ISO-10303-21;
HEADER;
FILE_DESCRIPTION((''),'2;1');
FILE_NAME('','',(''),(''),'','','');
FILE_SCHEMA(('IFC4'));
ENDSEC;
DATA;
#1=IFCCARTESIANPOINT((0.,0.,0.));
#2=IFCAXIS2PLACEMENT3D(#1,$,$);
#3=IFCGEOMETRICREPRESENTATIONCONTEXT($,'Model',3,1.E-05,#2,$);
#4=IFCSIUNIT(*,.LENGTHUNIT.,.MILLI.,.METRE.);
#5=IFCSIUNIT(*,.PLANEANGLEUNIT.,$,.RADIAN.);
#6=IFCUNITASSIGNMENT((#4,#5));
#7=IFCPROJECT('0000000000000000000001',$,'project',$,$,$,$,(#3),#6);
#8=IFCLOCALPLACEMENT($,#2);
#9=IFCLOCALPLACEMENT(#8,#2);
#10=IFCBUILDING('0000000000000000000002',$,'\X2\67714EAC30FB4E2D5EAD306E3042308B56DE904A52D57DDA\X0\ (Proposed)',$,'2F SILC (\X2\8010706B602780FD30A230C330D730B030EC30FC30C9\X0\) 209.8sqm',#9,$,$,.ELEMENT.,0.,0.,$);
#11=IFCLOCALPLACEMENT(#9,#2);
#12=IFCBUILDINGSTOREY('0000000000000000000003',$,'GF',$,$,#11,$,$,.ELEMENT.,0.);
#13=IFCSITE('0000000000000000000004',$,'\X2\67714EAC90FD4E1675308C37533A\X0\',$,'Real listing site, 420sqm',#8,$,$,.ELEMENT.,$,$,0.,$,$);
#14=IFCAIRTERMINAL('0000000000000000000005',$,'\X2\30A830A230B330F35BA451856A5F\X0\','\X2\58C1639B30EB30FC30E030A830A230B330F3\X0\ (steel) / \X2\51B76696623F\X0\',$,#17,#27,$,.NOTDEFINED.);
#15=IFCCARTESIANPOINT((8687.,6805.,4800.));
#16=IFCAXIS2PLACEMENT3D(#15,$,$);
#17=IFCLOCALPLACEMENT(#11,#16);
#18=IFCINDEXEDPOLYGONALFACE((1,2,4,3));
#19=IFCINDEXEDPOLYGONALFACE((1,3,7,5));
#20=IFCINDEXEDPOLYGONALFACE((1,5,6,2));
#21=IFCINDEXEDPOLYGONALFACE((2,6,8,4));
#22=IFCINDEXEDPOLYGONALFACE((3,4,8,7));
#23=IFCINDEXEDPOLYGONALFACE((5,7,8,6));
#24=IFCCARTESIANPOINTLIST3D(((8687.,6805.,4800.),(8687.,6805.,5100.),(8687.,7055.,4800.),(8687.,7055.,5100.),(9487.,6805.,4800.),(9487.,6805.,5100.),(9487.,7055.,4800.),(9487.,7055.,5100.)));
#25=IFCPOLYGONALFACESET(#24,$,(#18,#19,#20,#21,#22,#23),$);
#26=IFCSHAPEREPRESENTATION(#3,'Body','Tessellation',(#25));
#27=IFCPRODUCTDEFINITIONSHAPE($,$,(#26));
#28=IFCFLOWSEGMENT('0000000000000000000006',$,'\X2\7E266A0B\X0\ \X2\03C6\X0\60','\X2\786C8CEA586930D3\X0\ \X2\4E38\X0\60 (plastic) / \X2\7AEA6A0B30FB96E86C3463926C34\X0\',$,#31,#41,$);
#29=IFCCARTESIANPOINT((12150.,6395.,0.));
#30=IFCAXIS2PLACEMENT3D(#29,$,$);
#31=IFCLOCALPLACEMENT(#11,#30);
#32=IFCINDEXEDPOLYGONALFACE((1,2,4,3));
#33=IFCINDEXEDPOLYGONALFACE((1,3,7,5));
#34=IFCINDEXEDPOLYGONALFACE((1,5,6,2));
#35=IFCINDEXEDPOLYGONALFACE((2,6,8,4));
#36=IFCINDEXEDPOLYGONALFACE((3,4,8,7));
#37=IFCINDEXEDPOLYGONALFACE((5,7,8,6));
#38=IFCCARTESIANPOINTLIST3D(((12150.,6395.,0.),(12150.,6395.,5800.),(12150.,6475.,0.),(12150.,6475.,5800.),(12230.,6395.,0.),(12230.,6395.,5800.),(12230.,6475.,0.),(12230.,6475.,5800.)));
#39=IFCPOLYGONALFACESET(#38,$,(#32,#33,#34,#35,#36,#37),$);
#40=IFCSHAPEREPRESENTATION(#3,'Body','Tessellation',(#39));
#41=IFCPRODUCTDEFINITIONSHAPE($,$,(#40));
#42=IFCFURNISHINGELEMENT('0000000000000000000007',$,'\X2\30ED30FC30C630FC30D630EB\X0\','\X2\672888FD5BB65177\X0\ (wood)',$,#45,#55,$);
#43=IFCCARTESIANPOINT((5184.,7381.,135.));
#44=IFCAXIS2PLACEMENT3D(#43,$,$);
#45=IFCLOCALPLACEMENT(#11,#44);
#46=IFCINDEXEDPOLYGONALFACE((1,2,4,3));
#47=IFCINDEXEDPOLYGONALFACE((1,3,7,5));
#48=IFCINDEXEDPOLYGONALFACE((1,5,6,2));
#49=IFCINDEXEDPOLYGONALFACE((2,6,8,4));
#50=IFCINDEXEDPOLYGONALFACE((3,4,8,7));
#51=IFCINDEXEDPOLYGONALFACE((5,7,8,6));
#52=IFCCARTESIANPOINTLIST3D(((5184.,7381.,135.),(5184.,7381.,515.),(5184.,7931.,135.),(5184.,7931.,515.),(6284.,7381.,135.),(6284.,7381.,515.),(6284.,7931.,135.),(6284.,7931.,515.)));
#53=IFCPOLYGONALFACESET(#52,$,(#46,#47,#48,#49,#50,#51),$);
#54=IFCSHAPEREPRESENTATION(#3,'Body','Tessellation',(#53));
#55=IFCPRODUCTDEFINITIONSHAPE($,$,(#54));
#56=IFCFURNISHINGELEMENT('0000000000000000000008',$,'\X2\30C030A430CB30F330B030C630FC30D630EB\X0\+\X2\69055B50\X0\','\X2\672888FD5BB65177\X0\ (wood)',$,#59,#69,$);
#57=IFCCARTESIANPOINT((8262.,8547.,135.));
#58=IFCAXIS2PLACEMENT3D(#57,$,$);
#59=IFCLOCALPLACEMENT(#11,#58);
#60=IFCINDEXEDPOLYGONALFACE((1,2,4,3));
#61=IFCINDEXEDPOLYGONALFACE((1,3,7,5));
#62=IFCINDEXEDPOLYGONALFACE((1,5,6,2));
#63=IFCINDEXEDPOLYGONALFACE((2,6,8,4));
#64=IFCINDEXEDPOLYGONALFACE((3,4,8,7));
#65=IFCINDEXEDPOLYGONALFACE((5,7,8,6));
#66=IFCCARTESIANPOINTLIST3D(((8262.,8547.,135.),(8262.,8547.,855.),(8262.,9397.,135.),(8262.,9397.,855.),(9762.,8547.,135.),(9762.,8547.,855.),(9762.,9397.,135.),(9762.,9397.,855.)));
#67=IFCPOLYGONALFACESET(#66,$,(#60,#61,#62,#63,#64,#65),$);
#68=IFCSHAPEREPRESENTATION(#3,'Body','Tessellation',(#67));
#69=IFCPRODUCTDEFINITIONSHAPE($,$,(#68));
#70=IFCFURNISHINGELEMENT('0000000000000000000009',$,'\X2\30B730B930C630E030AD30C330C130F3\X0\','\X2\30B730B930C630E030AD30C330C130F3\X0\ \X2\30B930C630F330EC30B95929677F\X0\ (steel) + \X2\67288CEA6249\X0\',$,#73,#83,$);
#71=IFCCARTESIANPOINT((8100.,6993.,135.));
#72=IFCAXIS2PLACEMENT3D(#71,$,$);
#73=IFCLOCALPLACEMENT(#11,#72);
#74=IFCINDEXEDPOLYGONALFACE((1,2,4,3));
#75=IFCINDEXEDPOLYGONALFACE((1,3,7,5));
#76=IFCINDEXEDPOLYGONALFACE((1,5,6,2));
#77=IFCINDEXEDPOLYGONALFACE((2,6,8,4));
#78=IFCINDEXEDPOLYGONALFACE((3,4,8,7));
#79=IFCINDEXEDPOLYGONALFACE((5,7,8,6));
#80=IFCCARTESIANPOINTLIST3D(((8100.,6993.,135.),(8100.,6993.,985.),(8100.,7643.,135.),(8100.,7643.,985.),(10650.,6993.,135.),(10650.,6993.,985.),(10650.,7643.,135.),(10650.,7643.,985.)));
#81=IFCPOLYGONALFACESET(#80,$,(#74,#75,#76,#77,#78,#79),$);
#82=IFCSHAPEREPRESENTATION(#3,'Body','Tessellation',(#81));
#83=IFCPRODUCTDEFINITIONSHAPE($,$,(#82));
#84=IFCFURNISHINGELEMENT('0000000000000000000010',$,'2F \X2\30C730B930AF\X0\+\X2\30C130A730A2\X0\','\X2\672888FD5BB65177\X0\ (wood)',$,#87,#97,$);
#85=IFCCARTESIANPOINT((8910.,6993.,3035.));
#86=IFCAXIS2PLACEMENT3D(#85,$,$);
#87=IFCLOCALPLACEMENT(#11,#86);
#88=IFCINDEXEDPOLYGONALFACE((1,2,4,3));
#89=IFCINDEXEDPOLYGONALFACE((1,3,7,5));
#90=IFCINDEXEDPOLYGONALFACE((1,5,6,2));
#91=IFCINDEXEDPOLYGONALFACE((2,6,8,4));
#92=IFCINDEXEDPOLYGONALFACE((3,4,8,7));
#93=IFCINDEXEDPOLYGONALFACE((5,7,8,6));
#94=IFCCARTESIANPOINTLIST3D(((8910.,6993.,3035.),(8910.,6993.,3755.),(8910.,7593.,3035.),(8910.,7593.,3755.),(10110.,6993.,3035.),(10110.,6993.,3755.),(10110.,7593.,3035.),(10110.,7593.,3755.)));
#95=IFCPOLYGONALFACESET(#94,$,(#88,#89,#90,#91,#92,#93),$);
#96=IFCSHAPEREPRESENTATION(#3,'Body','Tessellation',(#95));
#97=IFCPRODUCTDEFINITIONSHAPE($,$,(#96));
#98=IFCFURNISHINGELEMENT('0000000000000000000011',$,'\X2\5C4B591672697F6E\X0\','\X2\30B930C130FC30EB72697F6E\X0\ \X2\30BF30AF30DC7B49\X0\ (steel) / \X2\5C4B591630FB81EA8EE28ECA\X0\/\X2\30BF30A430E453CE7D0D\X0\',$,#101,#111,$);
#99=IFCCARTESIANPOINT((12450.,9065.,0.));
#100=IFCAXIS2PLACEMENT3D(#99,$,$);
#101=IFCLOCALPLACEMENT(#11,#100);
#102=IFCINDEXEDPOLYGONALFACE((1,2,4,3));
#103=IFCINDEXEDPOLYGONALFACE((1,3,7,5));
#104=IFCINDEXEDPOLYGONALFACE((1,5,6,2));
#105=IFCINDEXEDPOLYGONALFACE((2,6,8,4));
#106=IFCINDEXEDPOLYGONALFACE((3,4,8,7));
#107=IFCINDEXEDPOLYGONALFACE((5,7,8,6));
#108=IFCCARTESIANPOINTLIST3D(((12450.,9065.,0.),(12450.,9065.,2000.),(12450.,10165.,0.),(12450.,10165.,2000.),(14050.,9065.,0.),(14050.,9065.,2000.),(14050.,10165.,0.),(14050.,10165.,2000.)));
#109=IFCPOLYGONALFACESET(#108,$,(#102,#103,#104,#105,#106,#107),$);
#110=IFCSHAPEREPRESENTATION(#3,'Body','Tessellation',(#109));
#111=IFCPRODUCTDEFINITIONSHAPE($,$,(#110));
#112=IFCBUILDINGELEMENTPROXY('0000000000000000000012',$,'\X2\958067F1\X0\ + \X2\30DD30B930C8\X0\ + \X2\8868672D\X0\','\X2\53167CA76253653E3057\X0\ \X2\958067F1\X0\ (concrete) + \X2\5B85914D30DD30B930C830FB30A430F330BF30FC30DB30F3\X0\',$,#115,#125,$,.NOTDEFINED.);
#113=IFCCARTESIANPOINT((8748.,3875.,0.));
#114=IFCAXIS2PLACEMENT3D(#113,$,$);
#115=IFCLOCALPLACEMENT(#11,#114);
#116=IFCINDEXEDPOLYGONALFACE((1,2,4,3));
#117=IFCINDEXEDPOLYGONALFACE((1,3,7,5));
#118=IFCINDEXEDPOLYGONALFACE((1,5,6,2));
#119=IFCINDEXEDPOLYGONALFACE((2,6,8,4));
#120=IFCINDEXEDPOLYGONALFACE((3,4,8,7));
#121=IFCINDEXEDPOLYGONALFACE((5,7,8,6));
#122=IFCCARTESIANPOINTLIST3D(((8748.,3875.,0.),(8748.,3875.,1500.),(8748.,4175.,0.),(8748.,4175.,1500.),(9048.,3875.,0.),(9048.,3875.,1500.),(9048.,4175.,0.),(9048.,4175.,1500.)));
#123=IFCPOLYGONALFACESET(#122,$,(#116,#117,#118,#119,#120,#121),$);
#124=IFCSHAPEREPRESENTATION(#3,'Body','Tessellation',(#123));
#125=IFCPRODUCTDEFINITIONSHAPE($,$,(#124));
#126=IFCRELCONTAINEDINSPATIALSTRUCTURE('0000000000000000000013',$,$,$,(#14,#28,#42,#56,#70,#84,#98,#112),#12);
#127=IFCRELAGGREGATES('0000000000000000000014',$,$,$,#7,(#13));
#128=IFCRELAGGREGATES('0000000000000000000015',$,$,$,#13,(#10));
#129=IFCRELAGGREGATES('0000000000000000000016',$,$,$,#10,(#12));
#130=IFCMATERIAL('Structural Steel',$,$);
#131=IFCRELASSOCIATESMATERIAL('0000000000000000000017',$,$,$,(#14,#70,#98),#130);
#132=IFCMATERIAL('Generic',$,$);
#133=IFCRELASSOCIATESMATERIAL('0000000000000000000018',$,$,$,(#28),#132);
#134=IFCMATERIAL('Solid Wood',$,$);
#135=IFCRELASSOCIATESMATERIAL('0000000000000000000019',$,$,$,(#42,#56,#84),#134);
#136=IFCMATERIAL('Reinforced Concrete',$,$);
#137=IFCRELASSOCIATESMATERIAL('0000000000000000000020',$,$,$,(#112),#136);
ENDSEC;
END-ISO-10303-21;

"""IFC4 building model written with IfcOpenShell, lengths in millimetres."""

from ifc_helpers import new_model, si_unit, frame, frame_2d, origin, place, context, project, spatial, rectangle, extrude, material, element, save


model = new_model("IFC4")

# Units and contexts
model_context = context("Model", 3, precision=1e-05, world=origin())
ifc_project = project(units=[si_unit("LENGTHUNIT", "METRE", prefix="MILLI"), si_unit("PLANEANGLEUNIT", "RADIAN")], contexts=[model_context])

# Site, building, storey
site_placement = place(None, origin())
site = spatial("IfcSite", under=ifc_project, at=site_placement, Name="東京都世田谷区", ObjectType="Real listing site, 420sqm", CompositionType="ELEMENT", RefElevation=0.0)
building_placement = place(site_placement, origin())
building = spatial("IfcBuilding", under=site, at=building_placement, Name="東京・中庭のある回遊動線 (Proposed)", ObjectType="2F SILC (耐火性能アップグレード) 209.8sqm", CompositionType="ELEMENT", ElevationOfRefHeight=0.0, ElevationOfTerrain=0.0)
storey_placement = place(building_placement, origin())
storey = spatial("IfcBuildingStorey", under=building, at=storey_placement, Name="GF", CompositionType="ELEMENT", Elevation=0.0)

# Shared definitions
ifc_material_1 = material(Name="Solid Wood")

# Shared definitions
ifc_material_2 = material(Name="Reinforced Concrete")

# Shared definitions
ifc_material_3 = material(Name="Structural Steel")

# Shared definitions
ifc_material_4 = material(Name="Generic")

# Air terminal
air_terminal_placement = place(storey_placement, frame((8687.0, 6805.0, 4800.0)))
element("IfcAirTerminal", 1, at=air_terminal_placement, inside=storey, material=ifc_material_3, Name="エアコン室内機", Description="壁掛ルームエアコン (steel) / 冷暖房", PredefinedType="NOTDEFINED", context=model_context, shape_type="SweptSolid", body=[
    extrude(rectangle(XDim=800.0, YDim=250.0, at=frame_2d((400.0, 125.0))), frame((8687.0, 6805.0, 4800.0)), (0.0, 0.0, 1.0), 300.0),
])

# Flow segment
flow_segment_placement = place(storey_placement, frame((12150.0, 6395.0, 0.0)))
element("IfcFlowSegment", 2, at=flow_segment_placement, inside=storey, material=ifc_material_4, Name="縦樋 φ60", Description="硬質塩ビ 丸60 (plastic) / 竪樋・雨水排水", context=model_context, shape_type="SweptSolid", body=[
    extrude(rectangle(XDim=80.0, YDim=80.0, at=frame_2d((40.0, 40.0))), frame((12150.0, 6395.0, 0.0)), (0.0, 0.0, 1.0), 5800.0),
])

# Furnishing elements
furnishing_1_placement = place(storey_placement, frame((5184.0, 7381.0, 135.0)))
element("IfcFurnishingElement", 3, at=furnishing_1_placement, inside=storey, material=ifc_material_1, Name="ローテーブル", Description="木製家具 (wood)", context=model_context, shape_type="SweptSolid", body=[
    extrude(rectangle(XDim=1100.0, YDim=550.0, at=frame_2d((550.0, 275.0))), frame((5184.0, 7381.0, 135.0)), (0.0, 0.0, 1.0), 380.0),
])
furnishing_2_placement = place(storey_placement, frame((8262.0, 8547.0, 135.0)))
element("IfcFurnishingElement", 4, at=furnishing_2_placement, inside=storey, material=ifc_material_1, Name="ダイニングテーブル+椅子", Description="木製家具 (wood)", context=model_context, shape_type="SweptSolid", body=[
    extrude(rectangle(XDim=1500.0, YDim=850.0, at=frame_2d((750.0, 425.0))), frame((8262.0, 8547.0, 135.0)), (0.0, 0.0, 1.0), 720.0),
])
furnishing_3_placement = place(storey_placement, frame((8100.0, 6993.0, 135.0)))
element("IfcFurnishingElement", 5, at=furnishing_3_placement, inside=storey, material=ifc_material_3, Name="システムキッチン", Description="システムキッチン ステンレス天板 (steel) + 木質扉", context=model_context, shape_type="SweptSolid", body=[
    extrude(rectangle(XDim=2550.0, YDim=650.0, at=frame_2d((1275.0, 325.0))), frame((8100.0, 6993.0, 135.0)), (0.0, 0.0, 1.0), 850.0),
])
furnishing_4_placement = place(storey_placement, frame((8910.0, 6993.0, 3035.0)))
element("IfcFurnishingElement", 6, at=furnishing_4_placement, inside=storey, material=ifc_material_1, Name="2F デスク+チェア", Description="木製家具 (wood)", context=model_context, shape_type="SweptSolid", body=[
    extrude(rectangle(XDim=1200.0, YDim=600.0, at=frame_2d((600.0, 300.0))), frame((8910.0, 6993.0, 3035.0)), (0.0, 0.0, 1.0), 720.0),
])
furnishing_5_placement = place(storey_placement, frame((12450.0, 9065.0, 0.0)))
element("IfcFurnishingElement", 7, at=furnishing_5_placement, inside=storey, material=ifc_material_3, Name="屋外物置", Description="スチール物置 タクボ等 (steel) / 屋外・自転車/タイヤ収納", context=model_context, shape_type="SweptSolid", body=[
    extrude(rectangle(XDim=1600.0, YDim=1100.0, at=frame_2d((800.0, 550.0))), frame((12450.0, 9065.0, 0.0)), (0.0, 0.0, 1.0), 2000.0),
])

# Building element proxy
proxy_placement = place(storey_placement, frame((8748.0, 3875.0, 0.0)))
element("IfcBuildingElementProxy", 8, at=proxy_placement, inside=storey, material=ifc_material_2, Name="門柱 + ポスト + 表札", Description="化粧打放し 門柱 (concrete) + 宅配ポスト・インターホン", PredefinedType="NOTDEFINED", context=model_context, shape_type="SweptSolid", body=[
    extrude(rectangle(XDim=300.0, YDim=300.0, at=frame_2d((150.0, 150.0))), frame((8748.0, 3875.0, 0.0)), (0.0, 0.0, 1.0), 1500.0),
])

save(model, "model.ifc")
